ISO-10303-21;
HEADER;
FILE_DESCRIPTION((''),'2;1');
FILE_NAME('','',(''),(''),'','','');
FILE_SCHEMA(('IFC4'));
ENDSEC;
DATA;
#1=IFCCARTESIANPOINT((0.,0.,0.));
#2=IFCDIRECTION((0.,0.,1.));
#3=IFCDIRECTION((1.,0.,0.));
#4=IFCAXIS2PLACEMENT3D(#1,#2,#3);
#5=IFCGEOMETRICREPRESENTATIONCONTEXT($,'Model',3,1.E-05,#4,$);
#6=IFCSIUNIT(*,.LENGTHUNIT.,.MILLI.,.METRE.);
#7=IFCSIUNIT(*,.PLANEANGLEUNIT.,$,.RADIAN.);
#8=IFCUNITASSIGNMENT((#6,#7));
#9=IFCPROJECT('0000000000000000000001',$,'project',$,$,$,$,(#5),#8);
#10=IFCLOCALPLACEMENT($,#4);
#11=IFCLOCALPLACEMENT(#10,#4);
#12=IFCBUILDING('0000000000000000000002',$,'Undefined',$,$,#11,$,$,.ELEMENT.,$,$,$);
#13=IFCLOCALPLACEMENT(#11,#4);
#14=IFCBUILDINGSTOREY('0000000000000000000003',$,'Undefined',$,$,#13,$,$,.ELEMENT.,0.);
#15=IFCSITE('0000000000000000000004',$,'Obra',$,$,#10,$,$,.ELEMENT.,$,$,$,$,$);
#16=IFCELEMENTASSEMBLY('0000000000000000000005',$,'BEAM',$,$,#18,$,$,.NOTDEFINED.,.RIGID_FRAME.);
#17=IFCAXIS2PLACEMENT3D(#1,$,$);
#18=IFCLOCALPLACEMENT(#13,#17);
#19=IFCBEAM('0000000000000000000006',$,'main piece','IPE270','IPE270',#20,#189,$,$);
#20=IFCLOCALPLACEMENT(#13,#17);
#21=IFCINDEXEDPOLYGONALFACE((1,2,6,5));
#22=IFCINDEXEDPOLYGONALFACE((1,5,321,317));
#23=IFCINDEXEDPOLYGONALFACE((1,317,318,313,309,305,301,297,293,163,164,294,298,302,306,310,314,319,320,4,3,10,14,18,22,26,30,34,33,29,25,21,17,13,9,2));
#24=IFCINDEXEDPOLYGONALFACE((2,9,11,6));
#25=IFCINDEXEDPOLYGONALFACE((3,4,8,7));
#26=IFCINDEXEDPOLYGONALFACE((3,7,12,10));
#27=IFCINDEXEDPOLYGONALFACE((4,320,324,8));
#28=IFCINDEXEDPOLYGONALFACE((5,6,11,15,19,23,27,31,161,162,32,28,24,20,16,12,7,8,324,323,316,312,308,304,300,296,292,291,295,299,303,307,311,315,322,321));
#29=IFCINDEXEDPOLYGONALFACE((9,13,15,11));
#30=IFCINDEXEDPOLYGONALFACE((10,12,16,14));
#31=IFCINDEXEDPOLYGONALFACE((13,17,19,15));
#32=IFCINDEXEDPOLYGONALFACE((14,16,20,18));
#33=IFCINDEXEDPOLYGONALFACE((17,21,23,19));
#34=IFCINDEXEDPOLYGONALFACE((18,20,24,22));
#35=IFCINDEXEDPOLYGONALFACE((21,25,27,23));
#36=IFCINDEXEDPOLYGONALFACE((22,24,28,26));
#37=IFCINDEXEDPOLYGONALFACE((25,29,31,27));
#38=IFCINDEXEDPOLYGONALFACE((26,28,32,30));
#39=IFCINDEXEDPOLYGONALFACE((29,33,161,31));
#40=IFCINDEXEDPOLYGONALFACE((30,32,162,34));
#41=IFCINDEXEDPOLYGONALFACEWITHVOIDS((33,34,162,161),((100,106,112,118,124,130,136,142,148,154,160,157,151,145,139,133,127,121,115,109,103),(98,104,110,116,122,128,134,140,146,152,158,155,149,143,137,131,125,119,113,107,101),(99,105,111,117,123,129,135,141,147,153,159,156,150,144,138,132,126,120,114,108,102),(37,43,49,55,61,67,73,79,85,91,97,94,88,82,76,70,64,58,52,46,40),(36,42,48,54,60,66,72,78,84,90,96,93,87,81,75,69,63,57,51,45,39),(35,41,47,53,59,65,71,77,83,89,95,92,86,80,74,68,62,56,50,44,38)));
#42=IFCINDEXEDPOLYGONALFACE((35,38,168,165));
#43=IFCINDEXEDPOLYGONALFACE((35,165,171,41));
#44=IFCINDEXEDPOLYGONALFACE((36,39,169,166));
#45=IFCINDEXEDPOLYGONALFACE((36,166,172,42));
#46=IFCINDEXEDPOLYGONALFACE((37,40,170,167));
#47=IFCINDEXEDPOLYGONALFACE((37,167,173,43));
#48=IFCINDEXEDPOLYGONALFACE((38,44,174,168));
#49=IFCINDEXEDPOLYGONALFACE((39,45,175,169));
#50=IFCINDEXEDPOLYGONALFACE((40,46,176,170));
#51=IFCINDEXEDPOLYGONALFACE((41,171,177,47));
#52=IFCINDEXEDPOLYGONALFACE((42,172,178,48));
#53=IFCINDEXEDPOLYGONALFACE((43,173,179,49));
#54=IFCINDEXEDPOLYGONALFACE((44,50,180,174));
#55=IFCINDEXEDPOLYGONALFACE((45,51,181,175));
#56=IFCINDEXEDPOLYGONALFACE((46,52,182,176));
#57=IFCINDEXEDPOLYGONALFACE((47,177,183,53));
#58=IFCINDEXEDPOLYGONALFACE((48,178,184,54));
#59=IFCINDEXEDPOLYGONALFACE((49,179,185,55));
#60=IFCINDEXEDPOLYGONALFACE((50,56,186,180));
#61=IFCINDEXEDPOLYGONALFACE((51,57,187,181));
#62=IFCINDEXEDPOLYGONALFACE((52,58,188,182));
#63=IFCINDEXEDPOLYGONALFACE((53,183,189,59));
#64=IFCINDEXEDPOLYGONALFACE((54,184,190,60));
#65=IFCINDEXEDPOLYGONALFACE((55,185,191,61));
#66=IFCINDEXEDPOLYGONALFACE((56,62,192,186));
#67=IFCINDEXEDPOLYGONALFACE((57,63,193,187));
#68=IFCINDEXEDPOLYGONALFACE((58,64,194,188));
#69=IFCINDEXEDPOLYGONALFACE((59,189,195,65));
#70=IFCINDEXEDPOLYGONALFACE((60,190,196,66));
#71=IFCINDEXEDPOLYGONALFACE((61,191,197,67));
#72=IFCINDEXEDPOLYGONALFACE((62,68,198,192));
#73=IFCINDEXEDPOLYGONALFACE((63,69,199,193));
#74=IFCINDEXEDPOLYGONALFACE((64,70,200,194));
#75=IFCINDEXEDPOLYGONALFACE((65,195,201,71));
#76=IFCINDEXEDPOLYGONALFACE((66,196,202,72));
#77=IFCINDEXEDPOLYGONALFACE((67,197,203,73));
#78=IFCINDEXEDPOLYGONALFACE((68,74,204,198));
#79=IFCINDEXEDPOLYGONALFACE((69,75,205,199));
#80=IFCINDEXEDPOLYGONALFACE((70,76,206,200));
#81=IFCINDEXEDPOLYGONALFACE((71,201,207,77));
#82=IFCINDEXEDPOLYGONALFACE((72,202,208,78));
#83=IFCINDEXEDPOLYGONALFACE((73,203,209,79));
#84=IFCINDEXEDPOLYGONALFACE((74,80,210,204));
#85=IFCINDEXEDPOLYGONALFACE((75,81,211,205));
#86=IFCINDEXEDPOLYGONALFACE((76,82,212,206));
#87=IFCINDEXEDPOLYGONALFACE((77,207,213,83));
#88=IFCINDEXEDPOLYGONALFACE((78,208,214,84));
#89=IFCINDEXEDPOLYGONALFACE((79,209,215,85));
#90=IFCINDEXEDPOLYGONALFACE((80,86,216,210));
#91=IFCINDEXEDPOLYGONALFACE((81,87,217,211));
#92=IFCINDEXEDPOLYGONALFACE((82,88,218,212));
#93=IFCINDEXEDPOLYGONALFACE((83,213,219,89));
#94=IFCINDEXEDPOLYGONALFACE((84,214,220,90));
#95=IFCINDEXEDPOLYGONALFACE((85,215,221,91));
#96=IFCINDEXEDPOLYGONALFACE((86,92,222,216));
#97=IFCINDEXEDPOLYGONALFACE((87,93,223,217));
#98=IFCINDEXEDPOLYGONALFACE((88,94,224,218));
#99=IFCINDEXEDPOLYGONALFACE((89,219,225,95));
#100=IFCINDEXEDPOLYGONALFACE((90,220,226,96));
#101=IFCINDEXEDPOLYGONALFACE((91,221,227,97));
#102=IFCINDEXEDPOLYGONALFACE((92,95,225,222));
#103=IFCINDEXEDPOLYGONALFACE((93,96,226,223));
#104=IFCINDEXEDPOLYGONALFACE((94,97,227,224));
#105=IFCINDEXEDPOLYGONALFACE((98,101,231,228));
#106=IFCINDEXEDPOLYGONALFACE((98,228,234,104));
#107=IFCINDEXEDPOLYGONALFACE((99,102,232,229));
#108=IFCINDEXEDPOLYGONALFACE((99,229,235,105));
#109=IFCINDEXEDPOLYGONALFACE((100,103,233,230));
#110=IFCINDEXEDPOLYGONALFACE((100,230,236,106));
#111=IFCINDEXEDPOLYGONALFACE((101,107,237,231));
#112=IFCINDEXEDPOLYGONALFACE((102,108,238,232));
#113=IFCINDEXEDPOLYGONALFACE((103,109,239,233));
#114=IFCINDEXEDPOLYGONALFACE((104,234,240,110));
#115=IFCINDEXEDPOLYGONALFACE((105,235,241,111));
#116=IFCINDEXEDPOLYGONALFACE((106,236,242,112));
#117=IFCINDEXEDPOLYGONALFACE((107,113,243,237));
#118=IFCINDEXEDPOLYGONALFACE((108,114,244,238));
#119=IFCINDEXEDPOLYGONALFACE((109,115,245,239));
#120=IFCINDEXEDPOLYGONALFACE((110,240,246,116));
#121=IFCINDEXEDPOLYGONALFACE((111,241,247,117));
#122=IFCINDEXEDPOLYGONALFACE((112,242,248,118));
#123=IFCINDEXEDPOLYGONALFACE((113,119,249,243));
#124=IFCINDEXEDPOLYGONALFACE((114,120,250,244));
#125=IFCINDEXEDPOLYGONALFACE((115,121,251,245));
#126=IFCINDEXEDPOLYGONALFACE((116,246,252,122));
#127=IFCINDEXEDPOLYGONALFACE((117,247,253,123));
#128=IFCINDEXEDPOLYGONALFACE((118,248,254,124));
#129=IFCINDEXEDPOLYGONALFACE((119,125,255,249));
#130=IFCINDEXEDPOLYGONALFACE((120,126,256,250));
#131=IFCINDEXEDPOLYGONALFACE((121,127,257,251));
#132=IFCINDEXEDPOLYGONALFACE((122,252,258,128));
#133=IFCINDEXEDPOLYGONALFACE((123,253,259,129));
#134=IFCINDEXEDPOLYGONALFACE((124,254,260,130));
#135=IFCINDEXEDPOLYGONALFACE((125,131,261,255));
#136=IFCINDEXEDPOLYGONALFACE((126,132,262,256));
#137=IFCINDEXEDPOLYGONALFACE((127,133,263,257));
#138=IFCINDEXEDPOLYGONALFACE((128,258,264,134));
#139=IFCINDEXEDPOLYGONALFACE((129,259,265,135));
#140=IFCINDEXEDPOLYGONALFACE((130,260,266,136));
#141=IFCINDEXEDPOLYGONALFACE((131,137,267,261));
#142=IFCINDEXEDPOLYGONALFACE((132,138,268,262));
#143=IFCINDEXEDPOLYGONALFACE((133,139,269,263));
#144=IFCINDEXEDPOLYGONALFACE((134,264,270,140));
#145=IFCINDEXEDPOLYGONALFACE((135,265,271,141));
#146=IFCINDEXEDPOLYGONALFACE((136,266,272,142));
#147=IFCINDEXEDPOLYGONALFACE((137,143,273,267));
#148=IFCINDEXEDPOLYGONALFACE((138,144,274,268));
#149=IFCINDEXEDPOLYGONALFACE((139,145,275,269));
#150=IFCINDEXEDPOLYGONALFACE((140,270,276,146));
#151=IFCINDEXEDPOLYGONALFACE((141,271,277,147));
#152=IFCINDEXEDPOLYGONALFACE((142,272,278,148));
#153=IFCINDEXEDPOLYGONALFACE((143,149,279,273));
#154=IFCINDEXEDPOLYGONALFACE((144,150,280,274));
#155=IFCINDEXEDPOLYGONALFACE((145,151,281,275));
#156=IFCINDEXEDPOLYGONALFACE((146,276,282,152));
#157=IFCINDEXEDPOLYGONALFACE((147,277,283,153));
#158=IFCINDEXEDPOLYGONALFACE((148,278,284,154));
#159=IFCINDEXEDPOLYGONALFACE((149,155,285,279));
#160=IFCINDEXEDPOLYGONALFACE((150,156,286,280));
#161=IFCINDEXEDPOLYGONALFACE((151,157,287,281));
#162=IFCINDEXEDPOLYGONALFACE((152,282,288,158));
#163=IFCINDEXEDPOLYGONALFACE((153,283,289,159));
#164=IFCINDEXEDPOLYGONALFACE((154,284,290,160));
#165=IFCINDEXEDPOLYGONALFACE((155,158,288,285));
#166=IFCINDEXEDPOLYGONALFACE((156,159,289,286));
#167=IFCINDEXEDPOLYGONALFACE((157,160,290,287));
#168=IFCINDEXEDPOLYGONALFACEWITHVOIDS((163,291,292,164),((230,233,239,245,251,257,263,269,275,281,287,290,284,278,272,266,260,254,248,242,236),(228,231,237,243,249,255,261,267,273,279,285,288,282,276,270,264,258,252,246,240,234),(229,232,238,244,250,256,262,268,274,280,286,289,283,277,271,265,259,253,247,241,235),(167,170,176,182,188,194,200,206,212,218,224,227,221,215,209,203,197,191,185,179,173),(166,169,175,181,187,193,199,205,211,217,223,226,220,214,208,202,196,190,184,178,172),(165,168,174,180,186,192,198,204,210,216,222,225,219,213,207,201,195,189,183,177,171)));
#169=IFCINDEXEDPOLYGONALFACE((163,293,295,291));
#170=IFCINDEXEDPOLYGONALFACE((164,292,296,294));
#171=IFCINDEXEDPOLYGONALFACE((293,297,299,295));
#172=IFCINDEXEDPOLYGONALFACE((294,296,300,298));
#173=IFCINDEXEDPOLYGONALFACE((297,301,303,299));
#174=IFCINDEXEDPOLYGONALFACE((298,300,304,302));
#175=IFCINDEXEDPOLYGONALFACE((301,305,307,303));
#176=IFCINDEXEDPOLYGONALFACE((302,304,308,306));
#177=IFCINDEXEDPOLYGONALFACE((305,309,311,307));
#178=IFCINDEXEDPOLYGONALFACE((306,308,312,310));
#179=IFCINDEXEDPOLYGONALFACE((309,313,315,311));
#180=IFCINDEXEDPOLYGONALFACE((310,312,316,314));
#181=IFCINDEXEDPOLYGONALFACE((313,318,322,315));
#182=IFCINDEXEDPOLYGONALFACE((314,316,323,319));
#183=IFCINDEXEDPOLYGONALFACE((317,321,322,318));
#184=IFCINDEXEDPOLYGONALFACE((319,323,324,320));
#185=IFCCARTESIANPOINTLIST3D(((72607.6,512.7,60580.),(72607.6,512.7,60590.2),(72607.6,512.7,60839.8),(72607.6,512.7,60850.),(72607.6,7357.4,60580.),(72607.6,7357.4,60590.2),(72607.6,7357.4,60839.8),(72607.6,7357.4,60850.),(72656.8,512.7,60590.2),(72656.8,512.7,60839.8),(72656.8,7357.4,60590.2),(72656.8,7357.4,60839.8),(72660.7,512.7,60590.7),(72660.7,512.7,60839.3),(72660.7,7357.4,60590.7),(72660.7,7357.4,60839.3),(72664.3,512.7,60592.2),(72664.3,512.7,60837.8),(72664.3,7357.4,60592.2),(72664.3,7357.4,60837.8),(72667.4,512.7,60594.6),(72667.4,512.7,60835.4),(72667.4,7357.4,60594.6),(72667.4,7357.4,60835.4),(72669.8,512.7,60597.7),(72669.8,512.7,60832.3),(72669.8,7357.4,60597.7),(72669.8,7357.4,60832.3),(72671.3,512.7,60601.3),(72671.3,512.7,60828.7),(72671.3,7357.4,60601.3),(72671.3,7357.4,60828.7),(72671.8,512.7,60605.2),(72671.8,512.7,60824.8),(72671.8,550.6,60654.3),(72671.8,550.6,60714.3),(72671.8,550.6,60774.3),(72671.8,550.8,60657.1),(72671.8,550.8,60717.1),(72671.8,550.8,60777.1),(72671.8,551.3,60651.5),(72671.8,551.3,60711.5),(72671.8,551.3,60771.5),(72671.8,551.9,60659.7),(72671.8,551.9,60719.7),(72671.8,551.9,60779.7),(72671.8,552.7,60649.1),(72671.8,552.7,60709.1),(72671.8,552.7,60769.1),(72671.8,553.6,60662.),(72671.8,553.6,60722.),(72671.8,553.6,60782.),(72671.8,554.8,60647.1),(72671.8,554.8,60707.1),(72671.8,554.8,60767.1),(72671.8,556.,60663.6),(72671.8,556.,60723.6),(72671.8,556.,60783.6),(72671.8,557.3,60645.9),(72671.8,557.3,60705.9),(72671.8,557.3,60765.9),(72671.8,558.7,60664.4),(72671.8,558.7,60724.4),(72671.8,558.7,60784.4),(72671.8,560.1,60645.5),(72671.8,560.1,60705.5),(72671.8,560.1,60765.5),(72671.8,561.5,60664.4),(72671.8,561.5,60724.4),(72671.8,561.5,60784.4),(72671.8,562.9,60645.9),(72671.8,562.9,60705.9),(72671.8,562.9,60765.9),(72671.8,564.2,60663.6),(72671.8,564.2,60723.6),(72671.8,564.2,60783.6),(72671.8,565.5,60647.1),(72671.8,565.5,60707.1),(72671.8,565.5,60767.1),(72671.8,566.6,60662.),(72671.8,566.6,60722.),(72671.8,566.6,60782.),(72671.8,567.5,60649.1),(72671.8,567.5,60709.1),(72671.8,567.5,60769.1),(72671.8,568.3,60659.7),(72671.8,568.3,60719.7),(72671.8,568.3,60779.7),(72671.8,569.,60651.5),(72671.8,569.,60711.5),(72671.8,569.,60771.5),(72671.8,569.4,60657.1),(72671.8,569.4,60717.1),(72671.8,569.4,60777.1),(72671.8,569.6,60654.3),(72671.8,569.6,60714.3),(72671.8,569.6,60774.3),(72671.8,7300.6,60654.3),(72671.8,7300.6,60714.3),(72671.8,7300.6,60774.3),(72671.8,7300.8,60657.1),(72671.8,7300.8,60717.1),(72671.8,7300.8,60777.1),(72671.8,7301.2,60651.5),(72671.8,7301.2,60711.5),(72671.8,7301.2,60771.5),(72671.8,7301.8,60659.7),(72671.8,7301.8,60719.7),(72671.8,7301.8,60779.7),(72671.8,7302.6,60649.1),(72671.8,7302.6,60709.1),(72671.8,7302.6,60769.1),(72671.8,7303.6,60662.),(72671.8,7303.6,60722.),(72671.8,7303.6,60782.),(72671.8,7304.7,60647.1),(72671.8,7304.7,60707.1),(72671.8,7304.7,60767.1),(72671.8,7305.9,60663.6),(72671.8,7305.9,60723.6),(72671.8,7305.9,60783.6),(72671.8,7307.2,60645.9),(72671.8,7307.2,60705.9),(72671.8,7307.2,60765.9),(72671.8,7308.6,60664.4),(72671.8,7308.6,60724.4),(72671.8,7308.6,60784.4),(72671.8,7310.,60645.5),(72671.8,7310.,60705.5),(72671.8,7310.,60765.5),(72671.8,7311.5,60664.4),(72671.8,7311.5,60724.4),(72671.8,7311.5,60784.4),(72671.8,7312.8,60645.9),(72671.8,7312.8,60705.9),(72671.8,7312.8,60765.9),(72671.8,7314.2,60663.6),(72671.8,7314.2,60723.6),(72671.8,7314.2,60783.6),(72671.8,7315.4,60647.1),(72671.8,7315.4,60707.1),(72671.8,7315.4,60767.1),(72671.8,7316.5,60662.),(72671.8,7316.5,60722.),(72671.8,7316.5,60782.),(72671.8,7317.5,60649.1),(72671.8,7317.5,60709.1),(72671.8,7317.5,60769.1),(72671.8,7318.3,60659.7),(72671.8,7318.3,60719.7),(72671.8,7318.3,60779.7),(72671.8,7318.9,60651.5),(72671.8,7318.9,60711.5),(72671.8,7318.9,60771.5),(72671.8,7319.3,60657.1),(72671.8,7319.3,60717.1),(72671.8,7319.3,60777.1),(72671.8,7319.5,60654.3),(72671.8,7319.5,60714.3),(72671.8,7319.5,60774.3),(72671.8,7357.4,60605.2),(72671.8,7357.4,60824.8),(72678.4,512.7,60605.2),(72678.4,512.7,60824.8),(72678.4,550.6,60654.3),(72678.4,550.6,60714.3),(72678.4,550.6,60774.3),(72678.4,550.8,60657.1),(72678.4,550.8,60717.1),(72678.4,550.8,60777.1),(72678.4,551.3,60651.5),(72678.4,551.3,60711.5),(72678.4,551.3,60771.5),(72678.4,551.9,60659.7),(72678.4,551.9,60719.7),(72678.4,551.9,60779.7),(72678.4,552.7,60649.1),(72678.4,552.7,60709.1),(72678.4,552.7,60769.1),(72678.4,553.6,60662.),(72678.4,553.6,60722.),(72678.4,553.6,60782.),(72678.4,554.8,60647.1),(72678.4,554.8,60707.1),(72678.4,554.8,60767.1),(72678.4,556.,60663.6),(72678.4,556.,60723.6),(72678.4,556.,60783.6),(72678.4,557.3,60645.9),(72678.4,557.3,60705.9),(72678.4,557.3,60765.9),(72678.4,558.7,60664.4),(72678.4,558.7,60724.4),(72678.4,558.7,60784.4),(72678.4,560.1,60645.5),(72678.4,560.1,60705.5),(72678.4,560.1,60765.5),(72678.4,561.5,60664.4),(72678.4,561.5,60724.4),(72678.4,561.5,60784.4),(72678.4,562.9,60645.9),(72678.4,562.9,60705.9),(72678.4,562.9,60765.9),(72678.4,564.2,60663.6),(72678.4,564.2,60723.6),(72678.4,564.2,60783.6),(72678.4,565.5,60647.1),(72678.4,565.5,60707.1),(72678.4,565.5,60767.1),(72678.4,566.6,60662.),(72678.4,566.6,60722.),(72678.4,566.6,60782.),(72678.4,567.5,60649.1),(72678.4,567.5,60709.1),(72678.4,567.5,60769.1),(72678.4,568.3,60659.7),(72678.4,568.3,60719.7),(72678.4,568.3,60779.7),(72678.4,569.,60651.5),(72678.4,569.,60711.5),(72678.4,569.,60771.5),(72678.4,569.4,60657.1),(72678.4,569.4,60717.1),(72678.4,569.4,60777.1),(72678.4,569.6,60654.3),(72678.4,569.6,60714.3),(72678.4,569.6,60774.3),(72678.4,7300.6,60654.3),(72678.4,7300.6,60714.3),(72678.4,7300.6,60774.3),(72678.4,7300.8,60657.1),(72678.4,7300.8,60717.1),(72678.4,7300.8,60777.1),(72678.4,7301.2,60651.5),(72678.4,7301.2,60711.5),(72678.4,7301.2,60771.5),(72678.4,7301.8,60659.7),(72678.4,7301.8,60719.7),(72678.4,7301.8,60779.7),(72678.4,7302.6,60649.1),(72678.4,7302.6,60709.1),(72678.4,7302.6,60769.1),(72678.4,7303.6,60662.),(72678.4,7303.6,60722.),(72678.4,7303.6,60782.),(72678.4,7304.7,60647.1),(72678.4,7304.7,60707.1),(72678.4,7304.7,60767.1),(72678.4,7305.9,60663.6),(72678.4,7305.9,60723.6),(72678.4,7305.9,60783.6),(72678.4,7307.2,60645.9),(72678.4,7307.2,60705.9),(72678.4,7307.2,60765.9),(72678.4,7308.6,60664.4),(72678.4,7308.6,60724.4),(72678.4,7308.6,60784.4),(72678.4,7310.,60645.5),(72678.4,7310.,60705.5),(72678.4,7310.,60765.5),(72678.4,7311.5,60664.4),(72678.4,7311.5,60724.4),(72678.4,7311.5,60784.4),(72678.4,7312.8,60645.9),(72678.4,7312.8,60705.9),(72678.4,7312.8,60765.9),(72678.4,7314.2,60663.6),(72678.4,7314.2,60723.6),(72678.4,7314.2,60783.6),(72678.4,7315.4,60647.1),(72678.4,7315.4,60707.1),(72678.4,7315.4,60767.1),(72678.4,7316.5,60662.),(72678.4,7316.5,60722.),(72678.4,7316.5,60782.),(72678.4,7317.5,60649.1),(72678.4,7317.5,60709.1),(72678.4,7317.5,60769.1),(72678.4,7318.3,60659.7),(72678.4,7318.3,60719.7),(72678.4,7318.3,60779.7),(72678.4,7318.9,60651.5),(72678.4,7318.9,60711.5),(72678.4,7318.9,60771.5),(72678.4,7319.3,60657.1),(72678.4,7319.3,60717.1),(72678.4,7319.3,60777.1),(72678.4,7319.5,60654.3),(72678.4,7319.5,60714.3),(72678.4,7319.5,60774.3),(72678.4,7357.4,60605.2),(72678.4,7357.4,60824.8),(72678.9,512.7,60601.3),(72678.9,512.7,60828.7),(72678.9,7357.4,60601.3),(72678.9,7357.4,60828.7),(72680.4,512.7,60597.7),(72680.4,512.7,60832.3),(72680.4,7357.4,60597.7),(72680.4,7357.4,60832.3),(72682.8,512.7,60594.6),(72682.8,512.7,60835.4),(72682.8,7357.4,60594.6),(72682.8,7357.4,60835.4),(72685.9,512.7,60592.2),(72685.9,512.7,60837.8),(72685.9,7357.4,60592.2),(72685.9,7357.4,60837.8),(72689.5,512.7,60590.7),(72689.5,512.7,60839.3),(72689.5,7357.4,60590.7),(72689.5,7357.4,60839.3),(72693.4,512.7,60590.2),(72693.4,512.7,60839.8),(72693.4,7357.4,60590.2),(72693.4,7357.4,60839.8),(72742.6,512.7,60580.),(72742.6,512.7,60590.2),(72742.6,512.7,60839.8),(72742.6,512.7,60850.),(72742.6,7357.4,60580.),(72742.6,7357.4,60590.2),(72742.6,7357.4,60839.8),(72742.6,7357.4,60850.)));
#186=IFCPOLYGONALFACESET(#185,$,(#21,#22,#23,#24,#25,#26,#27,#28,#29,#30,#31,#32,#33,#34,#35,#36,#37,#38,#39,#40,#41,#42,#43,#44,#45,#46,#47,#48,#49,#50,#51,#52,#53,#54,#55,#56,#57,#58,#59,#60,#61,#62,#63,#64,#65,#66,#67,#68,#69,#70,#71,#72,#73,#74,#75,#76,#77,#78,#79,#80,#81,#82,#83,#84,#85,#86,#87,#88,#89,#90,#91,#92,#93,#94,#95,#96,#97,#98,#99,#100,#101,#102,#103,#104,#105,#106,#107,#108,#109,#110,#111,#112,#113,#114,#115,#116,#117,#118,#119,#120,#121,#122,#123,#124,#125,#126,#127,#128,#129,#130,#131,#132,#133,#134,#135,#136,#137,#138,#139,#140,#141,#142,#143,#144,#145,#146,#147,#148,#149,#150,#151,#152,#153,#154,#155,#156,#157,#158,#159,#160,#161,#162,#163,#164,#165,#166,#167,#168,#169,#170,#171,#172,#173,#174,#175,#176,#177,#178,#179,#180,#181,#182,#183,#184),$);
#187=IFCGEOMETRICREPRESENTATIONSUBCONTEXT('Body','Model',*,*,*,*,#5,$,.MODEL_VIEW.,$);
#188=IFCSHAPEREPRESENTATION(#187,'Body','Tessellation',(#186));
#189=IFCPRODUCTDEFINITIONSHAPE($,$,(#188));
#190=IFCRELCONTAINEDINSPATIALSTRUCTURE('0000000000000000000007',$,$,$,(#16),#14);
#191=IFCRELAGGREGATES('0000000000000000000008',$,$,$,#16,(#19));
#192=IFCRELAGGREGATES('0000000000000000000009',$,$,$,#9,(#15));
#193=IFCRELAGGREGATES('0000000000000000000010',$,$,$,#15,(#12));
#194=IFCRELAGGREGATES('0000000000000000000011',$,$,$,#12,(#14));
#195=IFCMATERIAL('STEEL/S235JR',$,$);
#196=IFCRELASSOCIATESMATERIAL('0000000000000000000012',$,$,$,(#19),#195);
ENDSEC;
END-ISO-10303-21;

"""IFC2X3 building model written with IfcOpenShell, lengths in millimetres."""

from ifc_helpers import new_model, si_unit, frame, origin_with_axes, origin_2d_with_axis, place, context, subcontext, project, spatial, circle, i_section, extrude, clip, halfspace, source, transform, mapped, material, element, aggregate, save


model = new_model("IFC2X3")

# Units and contexts
model_context = context("Model", 3, precision=1e-05, world=origin_with_axes())
body_context = subcontext(model_context, "Body", "Model", "MODEL_VIEW")
ifc_project = project(units=[si_unit("LENGTHUNIT", "METRE", prefix="MILLI"), si_unit("PLANEANGLEUNIT", "RADIAN")], contexts=[model_context])

# Site, building, storey
site_placement = place(None, origin_with_axes())
site = spatial("IfcSite", under=ifc_project, at=site_placement, Name="Obra", CompositionType="ELEMENT")
building_placement = place(site_placement, origin_with_axes())
building = spatial("IfcBuilding", under=site, at=building_placement, Name="Undefined", CompositionType="ELEMENT")
storey_placement = place(building_placement, origin_with_axes())
storey = spatial("IfcBuildingStorey", under=building, at=storey_placement, Name="Undefined", CompositionType="ELEMENT", Elevation=0.0)

# Shared definitions
ifc_material_1 = material(Name="STEEL/S235JR")

# Element assembly, beam, openings
assembly_1_placement = place(storey_placement, origin_with_axes())
assembly_1 = element("IfcElementAssembly", 1, at=assembly_1_placement, inside=storey, Name="BEAM", AssemblyPlace="NOTDEFINED", PredefinedType="RIGID_FRAME")
beam_1_placement = place(assembly_1_placement, frame((72675.1, 512.7, 60715.0), z_axis=(0.0, 0.0, 1.0), x_axis=(0.0, 1.0, 0.0)))
beam_1 = element("IfcBeam", 2, at=beam_1_placement, material=ifc_material_1, Name="main piece", Description="IPE270", ObjectType="IPE270", context=body_context, shape_type="Clipping", body=[
    clip(clip(extrude(i_section(OverallWidth=135.0, OverallDepth=270.0, WebThickness=6.6, FlangeThickness=10.2, FilletRadius=15.0, at=origin_2d_with_axis()), frame((6844.7, 0.0, 0.0), z_axis=(-1.0, 0.0, 0.0), x_axis=(0.0, -1.0, 0.0)), (0.0, 0.0, 1.0), 6844.7), halfspace(frame((6846.8, -60.0, -120.0), z_axis=(1.0, 0.0, 0.0), x_axis=(0.0, 0.0, 1.0)), False)), halfspace(frame((-2.2, 60.0, -120.0), z_axis=(-1.0, -0.000021, 0.0), x_axis=(0.0, 0.0, 1.0)), False)),
])
shared_shape_1 = source(origin_with_axes(), body_context, "Body", "SweptSolid", [
    extrude(circle(Radius=9.5, at=origin_2d_with_axis()), frame((0.0, -3.4, 0.0), z_axis=(0.0, 1.0, 0.0), x_axis=(1.0, 0.0, 0.0)), (0.0, 0.0, 1.0), 6.8),
])
opening_1_placement = place(assembly_1_placement, frame((72675.1, 7360.0, 60835.0), z_axis=(-0.000019, -1.0, 0.0), x_axis=(0.0, 0.0, -1.0)))
element("IfcOpeningElement", 3, at=opening_1_placement, cuts=beam_1, ObjectType="Opening", context=body_context, shape_type="MappedRepresentation", body=[
    mapped(shared_shape_1, transform((60.0, 0.0, 50.0))),
    mapped(shared_shape_1, transform((120.0, 0.0, 50.0))),
    mapped(shared_shape_1, transform((180.0, 0.0, 50.0))),
])
shared_shape_2 = source(origin_with_axes(), body_context, "Body", "SweptSolid", [
    extrude(circle(Radius=9.5, at=origin_2d_with_axis()), frame((0.0, -3.4, 0.0), z_axis=(0.0, 1.0, 0.0), x_axis=(1.0, 0.0, 0.0)), (0.0, 0.0, 1.0), 6.8),
])
opening_2_placement = place(assembly_1_placement, frame((72675.1, 510.1, 60835.0), z_axis=(-0.000002, 1.0, 0.0), x_axis=(0.0, 0.0, -1.0)))
element("IfcOpeningElement", 4, at=opening_2_placement, cuts=beam_1, ObjectType="Opening", context=body_context, shape_type="MappedRepresentation", body=[
    mapped(shared_shape_2, transform((60.0, 0.0, 50.0))),
    mapped(shared_shape_2, transform((120.0, 0.0, 50.0))),
    mapped(shared_shape_2, transform((180.0, 0.0, 50.0))),
])
aggregate(assembly_1, [beam_1])

save(model, "model.ifc")
